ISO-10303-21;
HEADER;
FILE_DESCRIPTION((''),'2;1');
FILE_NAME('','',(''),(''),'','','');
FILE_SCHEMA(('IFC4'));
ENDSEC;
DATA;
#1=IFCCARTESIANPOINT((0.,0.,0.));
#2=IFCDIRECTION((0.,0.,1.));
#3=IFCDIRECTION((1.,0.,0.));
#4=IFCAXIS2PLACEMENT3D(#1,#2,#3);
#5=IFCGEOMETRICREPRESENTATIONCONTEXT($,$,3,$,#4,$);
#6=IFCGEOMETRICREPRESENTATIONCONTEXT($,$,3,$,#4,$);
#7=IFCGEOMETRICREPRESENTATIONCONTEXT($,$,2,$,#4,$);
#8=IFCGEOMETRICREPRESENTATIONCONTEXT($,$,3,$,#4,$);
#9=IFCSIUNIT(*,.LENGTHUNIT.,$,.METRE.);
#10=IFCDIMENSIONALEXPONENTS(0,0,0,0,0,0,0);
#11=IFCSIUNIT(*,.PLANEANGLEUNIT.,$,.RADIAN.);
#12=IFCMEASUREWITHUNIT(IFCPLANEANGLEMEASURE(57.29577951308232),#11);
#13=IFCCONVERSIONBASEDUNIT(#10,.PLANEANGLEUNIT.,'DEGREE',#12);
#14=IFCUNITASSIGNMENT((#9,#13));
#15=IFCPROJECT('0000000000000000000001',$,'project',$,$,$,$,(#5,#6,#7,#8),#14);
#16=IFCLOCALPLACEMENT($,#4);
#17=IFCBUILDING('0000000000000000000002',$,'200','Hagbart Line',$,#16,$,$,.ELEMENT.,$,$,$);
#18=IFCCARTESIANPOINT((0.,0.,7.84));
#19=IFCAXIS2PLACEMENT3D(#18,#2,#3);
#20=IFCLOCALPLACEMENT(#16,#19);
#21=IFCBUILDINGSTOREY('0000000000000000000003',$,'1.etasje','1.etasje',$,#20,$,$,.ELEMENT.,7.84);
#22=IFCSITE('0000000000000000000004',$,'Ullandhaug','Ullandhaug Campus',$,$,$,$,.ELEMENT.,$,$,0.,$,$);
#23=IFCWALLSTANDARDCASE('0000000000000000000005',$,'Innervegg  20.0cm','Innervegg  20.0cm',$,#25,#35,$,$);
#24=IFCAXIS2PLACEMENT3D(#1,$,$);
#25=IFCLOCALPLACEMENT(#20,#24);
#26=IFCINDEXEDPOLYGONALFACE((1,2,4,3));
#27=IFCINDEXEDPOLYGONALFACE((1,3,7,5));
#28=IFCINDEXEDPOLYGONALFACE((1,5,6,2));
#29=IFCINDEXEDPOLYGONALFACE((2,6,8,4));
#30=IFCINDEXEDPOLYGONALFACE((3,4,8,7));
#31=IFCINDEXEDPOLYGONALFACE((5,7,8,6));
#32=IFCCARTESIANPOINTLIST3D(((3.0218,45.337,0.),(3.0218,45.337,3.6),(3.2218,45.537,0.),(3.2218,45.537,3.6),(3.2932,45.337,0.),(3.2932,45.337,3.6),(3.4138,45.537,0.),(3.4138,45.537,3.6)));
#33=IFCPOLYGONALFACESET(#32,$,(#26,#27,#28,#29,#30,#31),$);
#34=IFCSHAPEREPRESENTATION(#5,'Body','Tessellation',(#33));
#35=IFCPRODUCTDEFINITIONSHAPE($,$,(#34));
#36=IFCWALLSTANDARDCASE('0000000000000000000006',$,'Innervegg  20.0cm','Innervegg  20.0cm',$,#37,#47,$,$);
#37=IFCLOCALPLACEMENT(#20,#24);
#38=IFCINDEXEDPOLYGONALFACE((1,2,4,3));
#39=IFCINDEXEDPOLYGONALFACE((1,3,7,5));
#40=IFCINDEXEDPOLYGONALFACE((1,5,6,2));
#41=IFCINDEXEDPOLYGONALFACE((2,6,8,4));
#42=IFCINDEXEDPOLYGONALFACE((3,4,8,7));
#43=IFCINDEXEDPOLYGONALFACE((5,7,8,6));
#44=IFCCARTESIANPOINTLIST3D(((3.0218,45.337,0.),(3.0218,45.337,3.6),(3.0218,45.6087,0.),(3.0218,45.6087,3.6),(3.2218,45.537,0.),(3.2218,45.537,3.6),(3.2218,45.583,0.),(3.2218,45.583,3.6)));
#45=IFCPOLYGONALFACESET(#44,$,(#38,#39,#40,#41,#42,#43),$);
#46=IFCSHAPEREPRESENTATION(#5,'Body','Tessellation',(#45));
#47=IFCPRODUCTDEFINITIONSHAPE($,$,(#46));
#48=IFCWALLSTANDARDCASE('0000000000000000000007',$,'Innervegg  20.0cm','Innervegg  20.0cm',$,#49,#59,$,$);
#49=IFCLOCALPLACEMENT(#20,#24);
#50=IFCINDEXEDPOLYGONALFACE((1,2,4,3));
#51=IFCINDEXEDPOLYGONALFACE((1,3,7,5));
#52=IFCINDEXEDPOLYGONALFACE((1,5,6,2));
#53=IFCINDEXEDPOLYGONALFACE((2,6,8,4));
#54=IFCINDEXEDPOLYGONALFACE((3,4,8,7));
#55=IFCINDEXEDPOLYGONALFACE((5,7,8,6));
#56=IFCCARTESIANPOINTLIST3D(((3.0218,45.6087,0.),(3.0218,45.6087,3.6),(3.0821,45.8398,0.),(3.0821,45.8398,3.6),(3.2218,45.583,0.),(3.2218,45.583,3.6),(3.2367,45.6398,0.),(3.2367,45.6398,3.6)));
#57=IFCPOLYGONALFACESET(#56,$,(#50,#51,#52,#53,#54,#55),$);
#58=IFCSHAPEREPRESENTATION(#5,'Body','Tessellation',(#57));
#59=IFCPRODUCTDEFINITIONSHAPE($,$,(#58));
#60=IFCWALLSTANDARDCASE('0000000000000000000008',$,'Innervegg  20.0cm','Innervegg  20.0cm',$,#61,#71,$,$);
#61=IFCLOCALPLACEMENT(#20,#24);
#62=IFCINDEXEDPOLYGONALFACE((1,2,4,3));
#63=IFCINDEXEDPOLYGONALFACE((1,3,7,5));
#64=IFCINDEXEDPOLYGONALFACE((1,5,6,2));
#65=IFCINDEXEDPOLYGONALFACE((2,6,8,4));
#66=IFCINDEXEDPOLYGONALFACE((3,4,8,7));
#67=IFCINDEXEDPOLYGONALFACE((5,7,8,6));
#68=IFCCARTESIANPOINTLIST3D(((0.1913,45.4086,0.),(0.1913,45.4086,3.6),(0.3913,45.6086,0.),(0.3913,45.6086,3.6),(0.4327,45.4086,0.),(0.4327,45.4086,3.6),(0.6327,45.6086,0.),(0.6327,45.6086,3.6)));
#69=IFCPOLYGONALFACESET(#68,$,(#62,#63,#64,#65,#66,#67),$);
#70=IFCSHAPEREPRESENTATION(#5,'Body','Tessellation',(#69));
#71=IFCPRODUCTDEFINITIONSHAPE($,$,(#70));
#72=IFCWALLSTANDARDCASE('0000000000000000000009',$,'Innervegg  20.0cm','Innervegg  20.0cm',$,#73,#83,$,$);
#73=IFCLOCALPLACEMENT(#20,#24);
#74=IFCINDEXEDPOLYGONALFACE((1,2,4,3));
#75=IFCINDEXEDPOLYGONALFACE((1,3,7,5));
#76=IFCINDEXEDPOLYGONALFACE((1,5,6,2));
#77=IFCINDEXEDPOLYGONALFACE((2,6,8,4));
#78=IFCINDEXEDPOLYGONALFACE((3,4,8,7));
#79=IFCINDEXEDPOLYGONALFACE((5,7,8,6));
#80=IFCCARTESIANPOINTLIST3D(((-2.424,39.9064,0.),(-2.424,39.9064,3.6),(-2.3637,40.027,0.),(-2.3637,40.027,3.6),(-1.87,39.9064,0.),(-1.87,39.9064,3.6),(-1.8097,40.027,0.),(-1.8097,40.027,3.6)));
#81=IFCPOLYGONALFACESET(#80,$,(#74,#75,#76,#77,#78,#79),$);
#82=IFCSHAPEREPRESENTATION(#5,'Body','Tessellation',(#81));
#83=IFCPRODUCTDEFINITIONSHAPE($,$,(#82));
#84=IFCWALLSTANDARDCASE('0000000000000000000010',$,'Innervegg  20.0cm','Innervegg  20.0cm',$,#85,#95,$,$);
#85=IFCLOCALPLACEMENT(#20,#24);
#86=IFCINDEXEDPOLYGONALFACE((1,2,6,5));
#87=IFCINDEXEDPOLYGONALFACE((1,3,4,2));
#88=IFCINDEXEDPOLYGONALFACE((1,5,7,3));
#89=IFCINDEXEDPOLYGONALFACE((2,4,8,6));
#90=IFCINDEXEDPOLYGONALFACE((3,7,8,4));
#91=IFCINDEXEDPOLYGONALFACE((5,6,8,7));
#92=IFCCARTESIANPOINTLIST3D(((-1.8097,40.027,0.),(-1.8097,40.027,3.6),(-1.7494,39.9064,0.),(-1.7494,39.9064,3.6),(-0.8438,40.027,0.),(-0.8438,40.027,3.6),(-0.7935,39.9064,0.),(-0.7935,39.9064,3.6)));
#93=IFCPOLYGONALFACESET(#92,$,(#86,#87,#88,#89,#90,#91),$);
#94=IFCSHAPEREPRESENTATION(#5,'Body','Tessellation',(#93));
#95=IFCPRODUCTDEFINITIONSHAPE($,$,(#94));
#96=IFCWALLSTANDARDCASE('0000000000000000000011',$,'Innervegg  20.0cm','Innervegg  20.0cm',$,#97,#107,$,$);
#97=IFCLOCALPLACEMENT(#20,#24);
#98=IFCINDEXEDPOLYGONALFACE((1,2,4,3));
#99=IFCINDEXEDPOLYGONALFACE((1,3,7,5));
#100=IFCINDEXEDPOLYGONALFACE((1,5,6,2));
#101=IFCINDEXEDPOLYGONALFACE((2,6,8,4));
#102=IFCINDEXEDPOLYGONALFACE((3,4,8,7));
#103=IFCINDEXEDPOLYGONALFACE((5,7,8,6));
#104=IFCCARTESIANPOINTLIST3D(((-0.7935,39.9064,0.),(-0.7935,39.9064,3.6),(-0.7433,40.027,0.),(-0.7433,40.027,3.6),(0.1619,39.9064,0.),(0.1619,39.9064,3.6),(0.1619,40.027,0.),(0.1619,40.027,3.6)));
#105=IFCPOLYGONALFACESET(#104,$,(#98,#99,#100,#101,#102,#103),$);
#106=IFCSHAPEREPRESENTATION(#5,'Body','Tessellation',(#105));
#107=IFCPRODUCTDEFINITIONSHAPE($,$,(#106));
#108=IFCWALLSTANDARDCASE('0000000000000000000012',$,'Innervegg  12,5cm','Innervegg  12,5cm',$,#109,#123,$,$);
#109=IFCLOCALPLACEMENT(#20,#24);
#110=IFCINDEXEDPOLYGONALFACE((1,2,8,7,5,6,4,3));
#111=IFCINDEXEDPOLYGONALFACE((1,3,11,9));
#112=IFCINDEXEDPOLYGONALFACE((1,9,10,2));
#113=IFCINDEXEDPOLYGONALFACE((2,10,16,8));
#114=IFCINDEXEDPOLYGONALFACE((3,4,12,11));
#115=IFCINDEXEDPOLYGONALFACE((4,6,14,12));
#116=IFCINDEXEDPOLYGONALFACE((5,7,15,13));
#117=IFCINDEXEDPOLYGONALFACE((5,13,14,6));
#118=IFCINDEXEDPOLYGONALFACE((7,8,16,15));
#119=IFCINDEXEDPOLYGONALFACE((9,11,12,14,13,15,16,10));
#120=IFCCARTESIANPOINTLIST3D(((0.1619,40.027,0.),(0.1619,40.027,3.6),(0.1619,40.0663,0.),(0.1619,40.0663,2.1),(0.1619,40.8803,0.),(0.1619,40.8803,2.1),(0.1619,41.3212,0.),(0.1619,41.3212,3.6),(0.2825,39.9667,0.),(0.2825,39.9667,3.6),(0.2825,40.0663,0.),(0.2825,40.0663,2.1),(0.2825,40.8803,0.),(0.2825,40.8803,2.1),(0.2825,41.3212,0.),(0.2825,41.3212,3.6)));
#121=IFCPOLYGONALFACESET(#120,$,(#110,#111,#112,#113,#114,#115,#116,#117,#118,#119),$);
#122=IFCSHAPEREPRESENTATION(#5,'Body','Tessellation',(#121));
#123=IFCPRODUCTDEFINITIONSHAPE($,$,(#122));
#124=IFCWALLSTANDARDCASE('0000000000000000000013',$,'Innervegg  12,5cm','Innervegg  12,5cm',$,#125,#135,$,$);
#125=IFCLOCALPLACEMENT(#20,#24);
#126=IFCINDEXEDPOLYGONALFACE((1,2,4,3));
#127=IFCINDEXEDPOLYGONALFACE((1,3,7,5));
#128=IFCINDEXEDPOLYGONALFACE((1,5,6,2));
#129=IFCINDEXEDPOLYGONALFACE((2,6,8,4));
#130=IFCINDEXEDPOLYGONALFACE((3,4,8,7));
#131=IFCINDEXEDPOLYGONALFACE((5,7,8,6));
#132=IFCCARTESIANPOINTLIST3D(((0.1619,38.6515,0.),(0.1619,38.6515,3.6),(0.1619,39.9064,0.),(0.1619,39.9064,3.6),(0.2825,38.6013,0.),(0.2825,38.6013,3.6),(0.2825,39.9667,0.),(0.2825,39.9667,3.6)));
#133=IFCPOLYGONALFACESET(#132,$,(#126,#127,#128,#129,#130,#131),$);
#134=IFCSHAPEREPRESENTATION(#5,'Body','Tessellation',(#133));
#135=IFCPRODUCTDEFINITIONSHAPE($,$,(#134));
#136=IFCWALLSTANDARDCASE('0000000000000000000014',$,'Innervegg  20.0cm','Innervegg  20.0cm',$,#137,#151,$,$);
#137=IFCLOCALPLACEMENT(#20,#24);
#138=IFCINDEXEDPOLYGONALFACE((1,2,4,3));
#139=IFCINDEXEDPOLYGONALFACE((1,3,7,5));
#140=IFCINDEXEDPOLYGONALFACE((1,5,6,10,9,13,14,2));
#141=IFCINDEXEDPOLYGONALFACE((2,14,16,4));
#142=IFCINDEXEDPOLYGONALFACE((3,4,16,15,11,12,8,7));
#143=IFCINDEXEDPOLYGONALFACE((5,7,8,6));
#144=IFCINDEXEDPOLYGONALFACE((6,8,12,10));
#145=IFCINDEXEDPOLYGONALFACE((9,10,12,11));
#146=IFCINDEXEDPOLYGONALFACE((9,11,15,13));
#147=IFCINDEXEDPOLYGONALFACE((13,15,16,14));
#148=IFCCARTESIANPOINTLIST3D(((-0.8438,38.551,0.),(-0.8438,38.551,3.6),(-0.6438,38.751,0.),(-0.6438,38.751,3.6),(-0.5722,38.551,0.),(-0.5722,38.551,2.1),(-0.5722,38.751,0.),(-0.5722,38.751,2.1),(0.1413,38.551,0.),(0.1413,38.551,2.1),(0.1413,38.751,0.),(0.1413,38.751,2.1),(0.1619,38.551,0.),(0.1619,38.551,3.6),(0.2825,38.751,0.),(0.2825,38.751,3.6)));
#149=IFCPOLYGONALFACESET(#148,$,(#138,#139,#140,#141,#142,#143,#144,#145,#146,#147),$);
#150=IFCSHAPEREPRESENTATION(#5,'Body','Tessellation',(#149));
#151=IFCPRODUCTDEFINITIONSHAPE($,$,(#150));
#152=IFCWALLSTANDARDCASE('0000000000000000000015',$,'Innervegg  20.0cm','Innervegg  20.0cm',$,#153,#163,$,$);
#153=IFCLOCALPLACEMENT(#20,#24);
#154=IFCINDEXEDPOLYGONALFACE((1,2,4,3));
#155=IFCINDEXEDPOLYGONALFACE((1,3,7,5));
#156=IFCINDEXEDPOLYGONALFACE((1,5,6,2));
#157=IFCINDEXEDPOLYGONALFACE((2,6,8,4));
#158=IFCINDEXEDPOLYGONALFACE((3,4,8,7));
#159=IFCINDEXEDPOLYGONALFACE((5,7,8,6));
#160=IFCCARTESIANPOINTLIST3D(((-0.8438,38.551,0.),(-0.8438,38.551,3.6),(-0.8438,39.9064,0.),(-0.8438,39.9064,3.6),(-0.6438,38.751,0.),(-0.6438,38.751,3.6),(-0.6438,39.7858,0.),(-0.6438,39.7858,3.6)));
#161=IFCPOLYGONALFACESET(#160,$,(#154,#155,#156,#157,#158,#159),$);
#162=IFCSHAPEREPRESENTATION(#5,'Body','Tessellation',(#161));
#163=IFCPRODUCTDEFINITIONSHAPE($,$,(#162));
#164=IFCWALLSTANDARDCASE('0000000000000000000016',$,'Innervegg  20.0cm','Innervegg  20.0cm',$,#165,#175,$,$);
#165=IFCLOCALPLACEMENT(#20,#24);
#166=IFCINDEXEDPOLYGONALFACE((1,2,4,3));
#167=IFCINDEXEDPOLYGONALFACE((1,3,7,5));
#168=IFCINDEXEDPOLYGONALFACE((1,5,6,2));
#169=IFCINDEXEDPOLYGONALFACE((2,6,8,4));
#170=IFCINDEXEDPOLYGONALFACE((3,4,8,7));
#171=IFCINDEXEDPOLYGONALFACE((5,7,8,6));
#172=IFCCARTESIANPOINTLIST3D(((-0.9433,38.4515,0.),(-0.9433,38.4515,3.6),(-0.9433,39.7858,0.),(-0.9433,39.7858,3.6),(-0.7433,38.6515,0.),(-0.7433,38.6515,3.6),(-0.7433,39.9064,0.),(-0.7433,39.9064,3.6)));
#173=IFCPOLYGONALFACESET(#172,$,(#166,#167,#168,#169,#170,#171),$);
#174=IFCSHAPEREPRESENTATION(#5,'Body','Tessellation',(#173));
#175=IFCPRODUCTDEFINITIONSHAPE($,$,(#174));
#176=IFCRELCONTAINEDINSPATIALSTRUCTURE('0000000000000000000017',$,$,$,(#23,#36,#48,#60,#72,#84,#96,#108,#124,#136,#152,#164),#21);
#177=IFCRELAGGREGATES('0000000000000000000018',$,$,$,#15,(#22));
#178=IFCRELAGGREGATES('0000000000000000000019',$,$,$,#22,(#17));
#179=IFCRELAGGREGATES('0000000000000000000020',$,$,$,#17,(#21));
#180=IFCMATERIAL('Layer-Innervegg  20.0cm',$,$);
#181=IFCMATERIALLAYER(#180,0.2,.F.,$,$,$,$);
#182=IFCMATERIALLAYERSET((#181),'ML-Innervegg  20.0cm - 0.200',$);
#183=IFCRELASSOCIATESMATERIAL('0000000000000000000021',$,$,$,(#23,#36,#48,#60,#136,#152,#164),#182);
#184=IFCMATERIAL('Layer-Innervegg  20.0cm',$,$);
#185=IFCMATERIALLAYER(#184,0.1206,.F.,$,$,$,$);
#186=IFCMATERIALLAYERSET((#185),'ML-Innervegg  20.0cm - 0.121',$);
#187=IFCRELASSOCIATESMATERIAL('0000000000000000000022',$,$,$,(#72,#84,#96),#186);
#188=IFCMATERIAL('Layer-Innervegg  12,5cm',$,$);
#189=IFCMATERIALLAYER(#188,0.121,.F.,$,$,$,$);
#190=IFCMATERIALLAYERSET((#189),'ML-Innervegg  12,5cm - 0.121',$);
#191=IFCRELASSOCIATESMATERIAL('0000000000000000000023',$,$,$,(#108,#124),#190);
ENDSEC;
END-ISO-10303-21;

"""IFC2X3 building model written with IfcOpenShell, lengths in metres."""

from ifc_helpers import new_model, entity, si_unit, converted_unit, frame, origin_with_axes, place, context, project, spatial, polyline, outline, extrude, material, layer, layer_set, layer_usage, element, save


model = new_model("IFC2X3")

# Units and contexts
context_of_model_1 = context(None, 3, world=origin_with_axes())
context_of_model_2 = context(None, 3, world=origin_with_axes())
context_of_model_3 = context(None, 2, world=origin_with_axes())
context_of_model_4 = context(None, 3, world=origin_with_axes())
ifc_project = project(units=[si_unit("LENGTHUNIT", "METRE"), converted_unit("PLANEANGLEUNIT", "DEGREE", entity("IfcPlaneAngleMeasure", 57.29577951308232), si_unit("PLANEANGLEUNIT", "RADIAN"), dimensions=[0, 0, 0, 0, 0, 0, 0])], contexts=[context_of_model_1, context_of_model_2, context_of_model_3, context_of_model_4])

# Site, building, storey
site = spatial("IfcSite", under=ifc_project, Name="Ullandhaug", Description="Ullandhaug Campus", CompositionType="ELEMENT", RefElevation=0.0)
building_placement = place(None, origin_with_axes())
building = spatial("IfcBuilding", under=site, at=building_placement, Name="200", Description="Hagbart Line", CompositionType="ELEMENT")
storey_placement = place(building_placement, frame((0.0, 0.0, 7.84), z_axis=(0.0, 0.0, 1.0), x_axis=(1.0, 0.0, 0.0)))
storey = spatial("IfcBuildingStorey", under=building, at=storey_placement, Name="1.etasje", Description="1.etasje", CompositionType="ELEMENT", Elevation=7.84)

# Shared definitions
ifc_material_1 = material(Name="Layer-Innervegg  20.0cm")
ifc_layer_1 = layer(ifc_material_1, 0.1206, ventilated=False)
ifc_layer_set_1 = layer_set([ifc_layer_1], Name="ML-Innervegg  20.0cm - 0.121")
ifc_layer_usage_1 = layer_usage(ifc_layer_set_1, "AXIS2", "POSITIVE", 0.0)
ifc_material_2 = material(Name="Layer-Innervegg  20.0cm")
ifc_layer_2 = layer(ifc_material_2, 0.2, ventilated=False)
ifc_layer_set_2 = layer_set([ifc_layer_2], Name="ML-Innervegg  20.0cm - 0.200")
ifc_layer_usage_2 = layer_usage(ifc_layer_set_2, "AXIS2", "POSITIVE", 0.0)
ifc_material_3 = material(Name="Layer-Innervegg  12,5cm")
ifc_layer_3 = layer(ifc_material_3, 0.121, ventilated=False)
ifc_layer_set_3 = layer_set([ifc_layer_3], Name="ML-Innervegg  12,5cm - 0.121")
ifc_layer_usage_3 = layer_usage(ifc_layer_set_3, "AXIS2", "POSITIVE", 0.0)

# Walls
wall_1_placement = place(storey_placement, frame((3.4138, 45.537, 0.0), z_axis=(0.0, 0.0, 1.0), x_axis=(-1.0, 0.0, 0.0)))
element("IfcWallStandardCase", 1, at=wall_1_placement, inside=storey, material=ifc_layer_usage_2, Name="Innervegg  20.0cm", Description="Innervegg  20.0cm", context=context_of_model_1, shape_type="SweptSolid", body=[
    extrude(outline(polyline([(0.0, 0.0), (0.1919, 0.0), (0.3919, 0.2), (0.1206, 0.2), (0.0, 0.0)])), frame((0.0, 0.0, 0.0), z_axis=(0.0, 0.0, 1.0), x_axis=(1.0, 0.0, 0.0)), (0.0, 0.0, 1.0), 3.6),
])
wall_2_placement = place(storey_placement, frame((3.2218, 45.537, 0.0), z_axis=(0.0, 0.0, 1.0), x_axis=(0.0, 1.0, 0.0)))
element("IfcWallStandardCase", 2, at=wall_2_placement, inside=storey, material=ifc_layer_usage_2, Name="Innervegg  20.0cm", Description="Innervegg  20.0cm", context=context_of_model_1, shape_type="SweptSolid", body=[
    extrude(outline(polyline([(0.0, 0.0), (0.046, 0.0), (0.0717, 0.2), (-0.2, 0.2), (0.0, 0.0)])), frame((0.0, 0.0, 0.0), z_axis=(0.0, 0.0, 1.0), x_axis=(1.0, 0.0, 0.0)), (0.0, 0.0, 1.0), 3.6),
])
wall_3_placement = place(storey_placement, frame((3.2218, 45.583, 0.0), z_axis=(0.0, 0.0, 1.0), x_axis=(0.252413, 0.96762, 0.0)))
element("IfcWallStandardCase", 3, at=wall_3_placement, inside=storey, material=ifc_layer_usage_2, Name="Innervegg  20.0cm", Description="Innervegg  20.0cm", context=context_of_model_1, shape_type="SweptSolid", body=[
    extrude(outline(polyline([(0.0, 0.0), (0.0587, 0.0), (0.2132, 0.2), (-0.0257, 0.2), (0.0, 0.0)])), frame((0.0, 0.0, 0.0), z_axis=(0.0, 0.0, 1.0), x_axis=(1.0, 0.0, 0.0)), (0.0, 0.0, 1.0), 3.6),
])
wall_4_placement = place(storey_placement, frame((0.1913, 45.4086, 0.0), z_axis=(0.0, 0.0, 1.0), x_axis=(1.0, 0.0, 0.0)))
element("IfcWallStandardCase", 4, at=wall_4_placement, inside=storey, material=ifc_layer_usage_2, Name="Innervegg  20.0cm", Description="Innervegg  20.0cm", context=context_of_model_1, shape_type="SweptSolid", body=[
    extrude(outline(polyline([(0.0, 0.0), (0.2415, 0.0), (0.4415, 0.2), (0.2, 0.2), (0.0, 0.0)])), origin_with_axes(), (0.0, 0.0, 1.0), 3.6),
])
wall_5_placement = place(storey_placement, frame((-2.424, 39.9064, 0.0), z_axis=(0.0, 0.0, 1.0), x_axis=(1.0, 0.0, 0.0)))
element("IfcWallStandardCase", 5, at=wall_5_placement, inside=storey, material=ifc_layer_usage_1, Name="Innervegg  20.0cm", Description="Innervegg  20.0cm", context=context_of_model_1, shape_type="SweptSolid", body=[
    extrude(outline(polyline([(0.0, 0.0), (0.554, 0.0), (0.6143, 0.1206), (0.0603, 0.1206), (0.0, 0.0)])), origin_with_axes(), (0.0, 0.0, 1.0), 3.6),
])
wall_6_placement = place(storey_placement, frame((-1.7494, 39.9064, 0.0), z_axis=(0.0, 0.0, 1.0), x_axis=(1.0, 0.0, 0.0)))
element("IfcWallStandardCase", 6, at=wall_6_placement, inside=storey, material=ifc_layer_usage_1, Name="Innervegg  20.0cm", Description="Innervegg  20.0cm", context=context_of_model_1, shape_type="SweptSolid", body=[
    extrude(outline(polyline([(0.0, 0.0), (0.9559, 0.0), (0.9056, 0.1206), (-0.0603, 0.1206), (0.0, 0.0)])), origin_with_axes(), (0.0, 0.0, 1.0), 3.6),
])
wall_7_placement = place(storey_placement, frame((-0.7935, 39.9064, 0.0), z_axis=(0.0, 0.0, 1.0), x_axis=(1.0, 0.0, 0.0)))
element("IfcWallStandardCase", 7, at=wall_7_placement, inside=storey, material=ifc_layer_usage_1, Name="Innervegg  20.0cm", Description="Innervegg  20.0cm", context=context_of_model_1, shape_type="SweptSolid", body=[
    extrude(outline(polyline([(0.0, 0.0), (0.9554, 0.0), (0.9554, 0.1206), (0.0502, 0.1206), (0.0, 0.0)])), origin_with_axes(), (0.0, 0.0, 1.0), 3.6),
])

# Wall, opening
wall_8_placement = place(storey_placement, frame((0.2825, 39.9667, 0.0), z_axis=(0.0, 0.0, 1.0), x_axis=(0.0, 1.0, 0.0)))
wall_8 = element("IfcWallStandardCase", 8, at=wall_8_placement, inside=storey, material=ifc_layer_usage_3, Name="Innervegg  12,5cm", Description="Innervegg  12,5cm", context=context_of_model_1, shape_type="SweptSolid", body=[
    extrude(outline(polyline([(0.0, 0.0), (1.3545, 0.0), (1.3545, 0.1206), (0.0603, 0.1206), (0.0, 0.0)])), frame((0.0, 0.0, 0.0), z_axis=(0.0, 0.0, 1.0), x_axis=(1.0, 0.0, 0.0)), (0.0, 0.0, 1.0), 3.6),
])
opening_1_placement = place(wall_8_placement, frame((0.0996, 0.1206, 0.0), z_axis=(0.0, 0.0, 1.0), x_axis=(1.0, 0.0, 0.0)))
element("IfcOpeningElement", 9, at=opening_1_placement, cuts=wall_8, context=context_of_model_1, shape_type="SweptSolid", body=[
    extrude(outline(polyline([(0.0, 0.0), (2.1, 0.0), (2.1, 0.814), (0.0, 0.814), (0.0, 0.0)])), frame((0.0, 0.0, 0.0), z_axis=(0.0, 1.0, 0.0), x_axis=(0.0, 0.0, 1.0)), (0.0, 0.0, -1.0), 0.1206),
])

# Wall
wall_9_placement = place(storey_placement, frame((0.1619, 39.9064, 0.0), z_axis=(0.0, 0.0, 1.0), x_axis=(0.0, -1.0, 0.0)))
element("IfcWallStandardCase", 10, at=wall_9_placement, inside=storey, material=ifc_layer_usage_3, Name="Innervegg  12,5cm", Description="Innervegg  12,5cm", context=context_of_model_1, shape_type="SweptSolid", body=[
    extrude(outline(polyline([(0.0, 0.0), (1.2549, 0.0), (1.3051, 0.1206), (-0.0603, 0.1206), (0.0, 0.0)])), frame((0.0, 0.0, 0.0), z_axis=(0.0, 0.0, 1.0), x_axis=(1.0, 0.0, 0.0)), (0.0, 0.0, 1.0), 3.6),
])

# Wall, opening
wall_10_placement = place(storey_placement, frame((0.2825, 38.751, 0.0), z_axis=(0.0, 0.0, 1.0), x_axis=(-1.0, 0.0, 0.0)))
wall_10 = element("IfcWallStandardCase", 11, at=wall_10_placement, inside=storey, material=ifc_layer_usage_2, Name="Innervegg  20.0cm", Description="Innervegg  20.0cm", context=context_of_model_1, shape_type="SweptSolid", body=[
    extrude(outline(polyline([(0.0, 0.0), (0.9263, 0.0), (1.1263, 0.2), (0.1206, 0.2), (0.0, 0.0)])), frame((0.0, 0.0, 0.0), z_axis=(0.0, 0.0, 1.0), x_axis=(1.0, 0.0, 0.0)), (0.0, 0.0, 1.0), 3.6),
])
opening_2_placement = place(wall_10_placement, frame((0.1412, 0.2, 0.0), z_axis=(0.0, 0.0, 1.0), x_axis=(1.0, 0.0, 0.0)))
element("IfcOpeningElement", 12, at=opening_2_placement, cuts=wall_10, context=context_of_model_1, shape_type="SweptSolid", body=[
    extrude(outline(polyline([(0.0, 0.0), (2.1, 0.0), (2.1, 0.7136), (0.0, 0.7136), (0.0, 0.0)])), frame((0.0, 0.0, 0.0), z_axis=(0.0, 1.0, 0.0), x_axis=(0.0, 0.0, 1.0)), (0.0, 0.0, -1.0), 0.2),
])

# Walls
wall_11_placement = place(storey_placement, frame((-0.6438, 38.751, 0.0), z_axis=(0.0, 0.0, 1.0), x_axis=(0.0, 1.0, 0.0)))
element("IfcWallStandardCase", 13, at=wall_11_placement, inside=storey, material=ifc_layer_usage_2, Name="Innervegg  20.0cm", Description="Innervegg  20.0cm", context=context_of_model_1, shape_type="SweptSolid", body=[
    extrude(outline(polyline([(0.0, 0.0), (1.0348, 0.0), (1.1554, 0.2), (-0.2, 0.2), (0.0, 0.0)])), frame((0.0, 0.0, 0.0), z_axis=(0.0, 0.0, 1.0), x_axis=(1.0, 0.0, 0.0)), (0.0, 0.0, 1.0), 3.6),
])
wall_12_placement = place(storey_placement, frame((-0.9433, 39.7858, 0.0), z_axis=(0.0, 0.0, 1.0), x_axis=(0.0, -1.0, 0.0)))
element("IfcWallStandardCase", 14, at=wall_12_placement, inside=storey, material=ifc_layer_usage_2, Name="Innervegg  20.0cm", Description="Innervegg  20.0cm", context=context_of_model_1, shape_type="SweptSolid", body=[
    extrude(outline(polyline([(0.0, 0.0), (1.3343, 0.0), (1.1343, 0.2), (-0.1206, 0.2), (0.0, 0.0)])), frame((0.0, 0.0, 0.0), z_axis=(0.0, 0.0, 1.0), x_axis=(1.0, 0.0, 0.0)), (0.0, 0.0, 1.0), 3.6),
])

save(model, "model.ifc")
